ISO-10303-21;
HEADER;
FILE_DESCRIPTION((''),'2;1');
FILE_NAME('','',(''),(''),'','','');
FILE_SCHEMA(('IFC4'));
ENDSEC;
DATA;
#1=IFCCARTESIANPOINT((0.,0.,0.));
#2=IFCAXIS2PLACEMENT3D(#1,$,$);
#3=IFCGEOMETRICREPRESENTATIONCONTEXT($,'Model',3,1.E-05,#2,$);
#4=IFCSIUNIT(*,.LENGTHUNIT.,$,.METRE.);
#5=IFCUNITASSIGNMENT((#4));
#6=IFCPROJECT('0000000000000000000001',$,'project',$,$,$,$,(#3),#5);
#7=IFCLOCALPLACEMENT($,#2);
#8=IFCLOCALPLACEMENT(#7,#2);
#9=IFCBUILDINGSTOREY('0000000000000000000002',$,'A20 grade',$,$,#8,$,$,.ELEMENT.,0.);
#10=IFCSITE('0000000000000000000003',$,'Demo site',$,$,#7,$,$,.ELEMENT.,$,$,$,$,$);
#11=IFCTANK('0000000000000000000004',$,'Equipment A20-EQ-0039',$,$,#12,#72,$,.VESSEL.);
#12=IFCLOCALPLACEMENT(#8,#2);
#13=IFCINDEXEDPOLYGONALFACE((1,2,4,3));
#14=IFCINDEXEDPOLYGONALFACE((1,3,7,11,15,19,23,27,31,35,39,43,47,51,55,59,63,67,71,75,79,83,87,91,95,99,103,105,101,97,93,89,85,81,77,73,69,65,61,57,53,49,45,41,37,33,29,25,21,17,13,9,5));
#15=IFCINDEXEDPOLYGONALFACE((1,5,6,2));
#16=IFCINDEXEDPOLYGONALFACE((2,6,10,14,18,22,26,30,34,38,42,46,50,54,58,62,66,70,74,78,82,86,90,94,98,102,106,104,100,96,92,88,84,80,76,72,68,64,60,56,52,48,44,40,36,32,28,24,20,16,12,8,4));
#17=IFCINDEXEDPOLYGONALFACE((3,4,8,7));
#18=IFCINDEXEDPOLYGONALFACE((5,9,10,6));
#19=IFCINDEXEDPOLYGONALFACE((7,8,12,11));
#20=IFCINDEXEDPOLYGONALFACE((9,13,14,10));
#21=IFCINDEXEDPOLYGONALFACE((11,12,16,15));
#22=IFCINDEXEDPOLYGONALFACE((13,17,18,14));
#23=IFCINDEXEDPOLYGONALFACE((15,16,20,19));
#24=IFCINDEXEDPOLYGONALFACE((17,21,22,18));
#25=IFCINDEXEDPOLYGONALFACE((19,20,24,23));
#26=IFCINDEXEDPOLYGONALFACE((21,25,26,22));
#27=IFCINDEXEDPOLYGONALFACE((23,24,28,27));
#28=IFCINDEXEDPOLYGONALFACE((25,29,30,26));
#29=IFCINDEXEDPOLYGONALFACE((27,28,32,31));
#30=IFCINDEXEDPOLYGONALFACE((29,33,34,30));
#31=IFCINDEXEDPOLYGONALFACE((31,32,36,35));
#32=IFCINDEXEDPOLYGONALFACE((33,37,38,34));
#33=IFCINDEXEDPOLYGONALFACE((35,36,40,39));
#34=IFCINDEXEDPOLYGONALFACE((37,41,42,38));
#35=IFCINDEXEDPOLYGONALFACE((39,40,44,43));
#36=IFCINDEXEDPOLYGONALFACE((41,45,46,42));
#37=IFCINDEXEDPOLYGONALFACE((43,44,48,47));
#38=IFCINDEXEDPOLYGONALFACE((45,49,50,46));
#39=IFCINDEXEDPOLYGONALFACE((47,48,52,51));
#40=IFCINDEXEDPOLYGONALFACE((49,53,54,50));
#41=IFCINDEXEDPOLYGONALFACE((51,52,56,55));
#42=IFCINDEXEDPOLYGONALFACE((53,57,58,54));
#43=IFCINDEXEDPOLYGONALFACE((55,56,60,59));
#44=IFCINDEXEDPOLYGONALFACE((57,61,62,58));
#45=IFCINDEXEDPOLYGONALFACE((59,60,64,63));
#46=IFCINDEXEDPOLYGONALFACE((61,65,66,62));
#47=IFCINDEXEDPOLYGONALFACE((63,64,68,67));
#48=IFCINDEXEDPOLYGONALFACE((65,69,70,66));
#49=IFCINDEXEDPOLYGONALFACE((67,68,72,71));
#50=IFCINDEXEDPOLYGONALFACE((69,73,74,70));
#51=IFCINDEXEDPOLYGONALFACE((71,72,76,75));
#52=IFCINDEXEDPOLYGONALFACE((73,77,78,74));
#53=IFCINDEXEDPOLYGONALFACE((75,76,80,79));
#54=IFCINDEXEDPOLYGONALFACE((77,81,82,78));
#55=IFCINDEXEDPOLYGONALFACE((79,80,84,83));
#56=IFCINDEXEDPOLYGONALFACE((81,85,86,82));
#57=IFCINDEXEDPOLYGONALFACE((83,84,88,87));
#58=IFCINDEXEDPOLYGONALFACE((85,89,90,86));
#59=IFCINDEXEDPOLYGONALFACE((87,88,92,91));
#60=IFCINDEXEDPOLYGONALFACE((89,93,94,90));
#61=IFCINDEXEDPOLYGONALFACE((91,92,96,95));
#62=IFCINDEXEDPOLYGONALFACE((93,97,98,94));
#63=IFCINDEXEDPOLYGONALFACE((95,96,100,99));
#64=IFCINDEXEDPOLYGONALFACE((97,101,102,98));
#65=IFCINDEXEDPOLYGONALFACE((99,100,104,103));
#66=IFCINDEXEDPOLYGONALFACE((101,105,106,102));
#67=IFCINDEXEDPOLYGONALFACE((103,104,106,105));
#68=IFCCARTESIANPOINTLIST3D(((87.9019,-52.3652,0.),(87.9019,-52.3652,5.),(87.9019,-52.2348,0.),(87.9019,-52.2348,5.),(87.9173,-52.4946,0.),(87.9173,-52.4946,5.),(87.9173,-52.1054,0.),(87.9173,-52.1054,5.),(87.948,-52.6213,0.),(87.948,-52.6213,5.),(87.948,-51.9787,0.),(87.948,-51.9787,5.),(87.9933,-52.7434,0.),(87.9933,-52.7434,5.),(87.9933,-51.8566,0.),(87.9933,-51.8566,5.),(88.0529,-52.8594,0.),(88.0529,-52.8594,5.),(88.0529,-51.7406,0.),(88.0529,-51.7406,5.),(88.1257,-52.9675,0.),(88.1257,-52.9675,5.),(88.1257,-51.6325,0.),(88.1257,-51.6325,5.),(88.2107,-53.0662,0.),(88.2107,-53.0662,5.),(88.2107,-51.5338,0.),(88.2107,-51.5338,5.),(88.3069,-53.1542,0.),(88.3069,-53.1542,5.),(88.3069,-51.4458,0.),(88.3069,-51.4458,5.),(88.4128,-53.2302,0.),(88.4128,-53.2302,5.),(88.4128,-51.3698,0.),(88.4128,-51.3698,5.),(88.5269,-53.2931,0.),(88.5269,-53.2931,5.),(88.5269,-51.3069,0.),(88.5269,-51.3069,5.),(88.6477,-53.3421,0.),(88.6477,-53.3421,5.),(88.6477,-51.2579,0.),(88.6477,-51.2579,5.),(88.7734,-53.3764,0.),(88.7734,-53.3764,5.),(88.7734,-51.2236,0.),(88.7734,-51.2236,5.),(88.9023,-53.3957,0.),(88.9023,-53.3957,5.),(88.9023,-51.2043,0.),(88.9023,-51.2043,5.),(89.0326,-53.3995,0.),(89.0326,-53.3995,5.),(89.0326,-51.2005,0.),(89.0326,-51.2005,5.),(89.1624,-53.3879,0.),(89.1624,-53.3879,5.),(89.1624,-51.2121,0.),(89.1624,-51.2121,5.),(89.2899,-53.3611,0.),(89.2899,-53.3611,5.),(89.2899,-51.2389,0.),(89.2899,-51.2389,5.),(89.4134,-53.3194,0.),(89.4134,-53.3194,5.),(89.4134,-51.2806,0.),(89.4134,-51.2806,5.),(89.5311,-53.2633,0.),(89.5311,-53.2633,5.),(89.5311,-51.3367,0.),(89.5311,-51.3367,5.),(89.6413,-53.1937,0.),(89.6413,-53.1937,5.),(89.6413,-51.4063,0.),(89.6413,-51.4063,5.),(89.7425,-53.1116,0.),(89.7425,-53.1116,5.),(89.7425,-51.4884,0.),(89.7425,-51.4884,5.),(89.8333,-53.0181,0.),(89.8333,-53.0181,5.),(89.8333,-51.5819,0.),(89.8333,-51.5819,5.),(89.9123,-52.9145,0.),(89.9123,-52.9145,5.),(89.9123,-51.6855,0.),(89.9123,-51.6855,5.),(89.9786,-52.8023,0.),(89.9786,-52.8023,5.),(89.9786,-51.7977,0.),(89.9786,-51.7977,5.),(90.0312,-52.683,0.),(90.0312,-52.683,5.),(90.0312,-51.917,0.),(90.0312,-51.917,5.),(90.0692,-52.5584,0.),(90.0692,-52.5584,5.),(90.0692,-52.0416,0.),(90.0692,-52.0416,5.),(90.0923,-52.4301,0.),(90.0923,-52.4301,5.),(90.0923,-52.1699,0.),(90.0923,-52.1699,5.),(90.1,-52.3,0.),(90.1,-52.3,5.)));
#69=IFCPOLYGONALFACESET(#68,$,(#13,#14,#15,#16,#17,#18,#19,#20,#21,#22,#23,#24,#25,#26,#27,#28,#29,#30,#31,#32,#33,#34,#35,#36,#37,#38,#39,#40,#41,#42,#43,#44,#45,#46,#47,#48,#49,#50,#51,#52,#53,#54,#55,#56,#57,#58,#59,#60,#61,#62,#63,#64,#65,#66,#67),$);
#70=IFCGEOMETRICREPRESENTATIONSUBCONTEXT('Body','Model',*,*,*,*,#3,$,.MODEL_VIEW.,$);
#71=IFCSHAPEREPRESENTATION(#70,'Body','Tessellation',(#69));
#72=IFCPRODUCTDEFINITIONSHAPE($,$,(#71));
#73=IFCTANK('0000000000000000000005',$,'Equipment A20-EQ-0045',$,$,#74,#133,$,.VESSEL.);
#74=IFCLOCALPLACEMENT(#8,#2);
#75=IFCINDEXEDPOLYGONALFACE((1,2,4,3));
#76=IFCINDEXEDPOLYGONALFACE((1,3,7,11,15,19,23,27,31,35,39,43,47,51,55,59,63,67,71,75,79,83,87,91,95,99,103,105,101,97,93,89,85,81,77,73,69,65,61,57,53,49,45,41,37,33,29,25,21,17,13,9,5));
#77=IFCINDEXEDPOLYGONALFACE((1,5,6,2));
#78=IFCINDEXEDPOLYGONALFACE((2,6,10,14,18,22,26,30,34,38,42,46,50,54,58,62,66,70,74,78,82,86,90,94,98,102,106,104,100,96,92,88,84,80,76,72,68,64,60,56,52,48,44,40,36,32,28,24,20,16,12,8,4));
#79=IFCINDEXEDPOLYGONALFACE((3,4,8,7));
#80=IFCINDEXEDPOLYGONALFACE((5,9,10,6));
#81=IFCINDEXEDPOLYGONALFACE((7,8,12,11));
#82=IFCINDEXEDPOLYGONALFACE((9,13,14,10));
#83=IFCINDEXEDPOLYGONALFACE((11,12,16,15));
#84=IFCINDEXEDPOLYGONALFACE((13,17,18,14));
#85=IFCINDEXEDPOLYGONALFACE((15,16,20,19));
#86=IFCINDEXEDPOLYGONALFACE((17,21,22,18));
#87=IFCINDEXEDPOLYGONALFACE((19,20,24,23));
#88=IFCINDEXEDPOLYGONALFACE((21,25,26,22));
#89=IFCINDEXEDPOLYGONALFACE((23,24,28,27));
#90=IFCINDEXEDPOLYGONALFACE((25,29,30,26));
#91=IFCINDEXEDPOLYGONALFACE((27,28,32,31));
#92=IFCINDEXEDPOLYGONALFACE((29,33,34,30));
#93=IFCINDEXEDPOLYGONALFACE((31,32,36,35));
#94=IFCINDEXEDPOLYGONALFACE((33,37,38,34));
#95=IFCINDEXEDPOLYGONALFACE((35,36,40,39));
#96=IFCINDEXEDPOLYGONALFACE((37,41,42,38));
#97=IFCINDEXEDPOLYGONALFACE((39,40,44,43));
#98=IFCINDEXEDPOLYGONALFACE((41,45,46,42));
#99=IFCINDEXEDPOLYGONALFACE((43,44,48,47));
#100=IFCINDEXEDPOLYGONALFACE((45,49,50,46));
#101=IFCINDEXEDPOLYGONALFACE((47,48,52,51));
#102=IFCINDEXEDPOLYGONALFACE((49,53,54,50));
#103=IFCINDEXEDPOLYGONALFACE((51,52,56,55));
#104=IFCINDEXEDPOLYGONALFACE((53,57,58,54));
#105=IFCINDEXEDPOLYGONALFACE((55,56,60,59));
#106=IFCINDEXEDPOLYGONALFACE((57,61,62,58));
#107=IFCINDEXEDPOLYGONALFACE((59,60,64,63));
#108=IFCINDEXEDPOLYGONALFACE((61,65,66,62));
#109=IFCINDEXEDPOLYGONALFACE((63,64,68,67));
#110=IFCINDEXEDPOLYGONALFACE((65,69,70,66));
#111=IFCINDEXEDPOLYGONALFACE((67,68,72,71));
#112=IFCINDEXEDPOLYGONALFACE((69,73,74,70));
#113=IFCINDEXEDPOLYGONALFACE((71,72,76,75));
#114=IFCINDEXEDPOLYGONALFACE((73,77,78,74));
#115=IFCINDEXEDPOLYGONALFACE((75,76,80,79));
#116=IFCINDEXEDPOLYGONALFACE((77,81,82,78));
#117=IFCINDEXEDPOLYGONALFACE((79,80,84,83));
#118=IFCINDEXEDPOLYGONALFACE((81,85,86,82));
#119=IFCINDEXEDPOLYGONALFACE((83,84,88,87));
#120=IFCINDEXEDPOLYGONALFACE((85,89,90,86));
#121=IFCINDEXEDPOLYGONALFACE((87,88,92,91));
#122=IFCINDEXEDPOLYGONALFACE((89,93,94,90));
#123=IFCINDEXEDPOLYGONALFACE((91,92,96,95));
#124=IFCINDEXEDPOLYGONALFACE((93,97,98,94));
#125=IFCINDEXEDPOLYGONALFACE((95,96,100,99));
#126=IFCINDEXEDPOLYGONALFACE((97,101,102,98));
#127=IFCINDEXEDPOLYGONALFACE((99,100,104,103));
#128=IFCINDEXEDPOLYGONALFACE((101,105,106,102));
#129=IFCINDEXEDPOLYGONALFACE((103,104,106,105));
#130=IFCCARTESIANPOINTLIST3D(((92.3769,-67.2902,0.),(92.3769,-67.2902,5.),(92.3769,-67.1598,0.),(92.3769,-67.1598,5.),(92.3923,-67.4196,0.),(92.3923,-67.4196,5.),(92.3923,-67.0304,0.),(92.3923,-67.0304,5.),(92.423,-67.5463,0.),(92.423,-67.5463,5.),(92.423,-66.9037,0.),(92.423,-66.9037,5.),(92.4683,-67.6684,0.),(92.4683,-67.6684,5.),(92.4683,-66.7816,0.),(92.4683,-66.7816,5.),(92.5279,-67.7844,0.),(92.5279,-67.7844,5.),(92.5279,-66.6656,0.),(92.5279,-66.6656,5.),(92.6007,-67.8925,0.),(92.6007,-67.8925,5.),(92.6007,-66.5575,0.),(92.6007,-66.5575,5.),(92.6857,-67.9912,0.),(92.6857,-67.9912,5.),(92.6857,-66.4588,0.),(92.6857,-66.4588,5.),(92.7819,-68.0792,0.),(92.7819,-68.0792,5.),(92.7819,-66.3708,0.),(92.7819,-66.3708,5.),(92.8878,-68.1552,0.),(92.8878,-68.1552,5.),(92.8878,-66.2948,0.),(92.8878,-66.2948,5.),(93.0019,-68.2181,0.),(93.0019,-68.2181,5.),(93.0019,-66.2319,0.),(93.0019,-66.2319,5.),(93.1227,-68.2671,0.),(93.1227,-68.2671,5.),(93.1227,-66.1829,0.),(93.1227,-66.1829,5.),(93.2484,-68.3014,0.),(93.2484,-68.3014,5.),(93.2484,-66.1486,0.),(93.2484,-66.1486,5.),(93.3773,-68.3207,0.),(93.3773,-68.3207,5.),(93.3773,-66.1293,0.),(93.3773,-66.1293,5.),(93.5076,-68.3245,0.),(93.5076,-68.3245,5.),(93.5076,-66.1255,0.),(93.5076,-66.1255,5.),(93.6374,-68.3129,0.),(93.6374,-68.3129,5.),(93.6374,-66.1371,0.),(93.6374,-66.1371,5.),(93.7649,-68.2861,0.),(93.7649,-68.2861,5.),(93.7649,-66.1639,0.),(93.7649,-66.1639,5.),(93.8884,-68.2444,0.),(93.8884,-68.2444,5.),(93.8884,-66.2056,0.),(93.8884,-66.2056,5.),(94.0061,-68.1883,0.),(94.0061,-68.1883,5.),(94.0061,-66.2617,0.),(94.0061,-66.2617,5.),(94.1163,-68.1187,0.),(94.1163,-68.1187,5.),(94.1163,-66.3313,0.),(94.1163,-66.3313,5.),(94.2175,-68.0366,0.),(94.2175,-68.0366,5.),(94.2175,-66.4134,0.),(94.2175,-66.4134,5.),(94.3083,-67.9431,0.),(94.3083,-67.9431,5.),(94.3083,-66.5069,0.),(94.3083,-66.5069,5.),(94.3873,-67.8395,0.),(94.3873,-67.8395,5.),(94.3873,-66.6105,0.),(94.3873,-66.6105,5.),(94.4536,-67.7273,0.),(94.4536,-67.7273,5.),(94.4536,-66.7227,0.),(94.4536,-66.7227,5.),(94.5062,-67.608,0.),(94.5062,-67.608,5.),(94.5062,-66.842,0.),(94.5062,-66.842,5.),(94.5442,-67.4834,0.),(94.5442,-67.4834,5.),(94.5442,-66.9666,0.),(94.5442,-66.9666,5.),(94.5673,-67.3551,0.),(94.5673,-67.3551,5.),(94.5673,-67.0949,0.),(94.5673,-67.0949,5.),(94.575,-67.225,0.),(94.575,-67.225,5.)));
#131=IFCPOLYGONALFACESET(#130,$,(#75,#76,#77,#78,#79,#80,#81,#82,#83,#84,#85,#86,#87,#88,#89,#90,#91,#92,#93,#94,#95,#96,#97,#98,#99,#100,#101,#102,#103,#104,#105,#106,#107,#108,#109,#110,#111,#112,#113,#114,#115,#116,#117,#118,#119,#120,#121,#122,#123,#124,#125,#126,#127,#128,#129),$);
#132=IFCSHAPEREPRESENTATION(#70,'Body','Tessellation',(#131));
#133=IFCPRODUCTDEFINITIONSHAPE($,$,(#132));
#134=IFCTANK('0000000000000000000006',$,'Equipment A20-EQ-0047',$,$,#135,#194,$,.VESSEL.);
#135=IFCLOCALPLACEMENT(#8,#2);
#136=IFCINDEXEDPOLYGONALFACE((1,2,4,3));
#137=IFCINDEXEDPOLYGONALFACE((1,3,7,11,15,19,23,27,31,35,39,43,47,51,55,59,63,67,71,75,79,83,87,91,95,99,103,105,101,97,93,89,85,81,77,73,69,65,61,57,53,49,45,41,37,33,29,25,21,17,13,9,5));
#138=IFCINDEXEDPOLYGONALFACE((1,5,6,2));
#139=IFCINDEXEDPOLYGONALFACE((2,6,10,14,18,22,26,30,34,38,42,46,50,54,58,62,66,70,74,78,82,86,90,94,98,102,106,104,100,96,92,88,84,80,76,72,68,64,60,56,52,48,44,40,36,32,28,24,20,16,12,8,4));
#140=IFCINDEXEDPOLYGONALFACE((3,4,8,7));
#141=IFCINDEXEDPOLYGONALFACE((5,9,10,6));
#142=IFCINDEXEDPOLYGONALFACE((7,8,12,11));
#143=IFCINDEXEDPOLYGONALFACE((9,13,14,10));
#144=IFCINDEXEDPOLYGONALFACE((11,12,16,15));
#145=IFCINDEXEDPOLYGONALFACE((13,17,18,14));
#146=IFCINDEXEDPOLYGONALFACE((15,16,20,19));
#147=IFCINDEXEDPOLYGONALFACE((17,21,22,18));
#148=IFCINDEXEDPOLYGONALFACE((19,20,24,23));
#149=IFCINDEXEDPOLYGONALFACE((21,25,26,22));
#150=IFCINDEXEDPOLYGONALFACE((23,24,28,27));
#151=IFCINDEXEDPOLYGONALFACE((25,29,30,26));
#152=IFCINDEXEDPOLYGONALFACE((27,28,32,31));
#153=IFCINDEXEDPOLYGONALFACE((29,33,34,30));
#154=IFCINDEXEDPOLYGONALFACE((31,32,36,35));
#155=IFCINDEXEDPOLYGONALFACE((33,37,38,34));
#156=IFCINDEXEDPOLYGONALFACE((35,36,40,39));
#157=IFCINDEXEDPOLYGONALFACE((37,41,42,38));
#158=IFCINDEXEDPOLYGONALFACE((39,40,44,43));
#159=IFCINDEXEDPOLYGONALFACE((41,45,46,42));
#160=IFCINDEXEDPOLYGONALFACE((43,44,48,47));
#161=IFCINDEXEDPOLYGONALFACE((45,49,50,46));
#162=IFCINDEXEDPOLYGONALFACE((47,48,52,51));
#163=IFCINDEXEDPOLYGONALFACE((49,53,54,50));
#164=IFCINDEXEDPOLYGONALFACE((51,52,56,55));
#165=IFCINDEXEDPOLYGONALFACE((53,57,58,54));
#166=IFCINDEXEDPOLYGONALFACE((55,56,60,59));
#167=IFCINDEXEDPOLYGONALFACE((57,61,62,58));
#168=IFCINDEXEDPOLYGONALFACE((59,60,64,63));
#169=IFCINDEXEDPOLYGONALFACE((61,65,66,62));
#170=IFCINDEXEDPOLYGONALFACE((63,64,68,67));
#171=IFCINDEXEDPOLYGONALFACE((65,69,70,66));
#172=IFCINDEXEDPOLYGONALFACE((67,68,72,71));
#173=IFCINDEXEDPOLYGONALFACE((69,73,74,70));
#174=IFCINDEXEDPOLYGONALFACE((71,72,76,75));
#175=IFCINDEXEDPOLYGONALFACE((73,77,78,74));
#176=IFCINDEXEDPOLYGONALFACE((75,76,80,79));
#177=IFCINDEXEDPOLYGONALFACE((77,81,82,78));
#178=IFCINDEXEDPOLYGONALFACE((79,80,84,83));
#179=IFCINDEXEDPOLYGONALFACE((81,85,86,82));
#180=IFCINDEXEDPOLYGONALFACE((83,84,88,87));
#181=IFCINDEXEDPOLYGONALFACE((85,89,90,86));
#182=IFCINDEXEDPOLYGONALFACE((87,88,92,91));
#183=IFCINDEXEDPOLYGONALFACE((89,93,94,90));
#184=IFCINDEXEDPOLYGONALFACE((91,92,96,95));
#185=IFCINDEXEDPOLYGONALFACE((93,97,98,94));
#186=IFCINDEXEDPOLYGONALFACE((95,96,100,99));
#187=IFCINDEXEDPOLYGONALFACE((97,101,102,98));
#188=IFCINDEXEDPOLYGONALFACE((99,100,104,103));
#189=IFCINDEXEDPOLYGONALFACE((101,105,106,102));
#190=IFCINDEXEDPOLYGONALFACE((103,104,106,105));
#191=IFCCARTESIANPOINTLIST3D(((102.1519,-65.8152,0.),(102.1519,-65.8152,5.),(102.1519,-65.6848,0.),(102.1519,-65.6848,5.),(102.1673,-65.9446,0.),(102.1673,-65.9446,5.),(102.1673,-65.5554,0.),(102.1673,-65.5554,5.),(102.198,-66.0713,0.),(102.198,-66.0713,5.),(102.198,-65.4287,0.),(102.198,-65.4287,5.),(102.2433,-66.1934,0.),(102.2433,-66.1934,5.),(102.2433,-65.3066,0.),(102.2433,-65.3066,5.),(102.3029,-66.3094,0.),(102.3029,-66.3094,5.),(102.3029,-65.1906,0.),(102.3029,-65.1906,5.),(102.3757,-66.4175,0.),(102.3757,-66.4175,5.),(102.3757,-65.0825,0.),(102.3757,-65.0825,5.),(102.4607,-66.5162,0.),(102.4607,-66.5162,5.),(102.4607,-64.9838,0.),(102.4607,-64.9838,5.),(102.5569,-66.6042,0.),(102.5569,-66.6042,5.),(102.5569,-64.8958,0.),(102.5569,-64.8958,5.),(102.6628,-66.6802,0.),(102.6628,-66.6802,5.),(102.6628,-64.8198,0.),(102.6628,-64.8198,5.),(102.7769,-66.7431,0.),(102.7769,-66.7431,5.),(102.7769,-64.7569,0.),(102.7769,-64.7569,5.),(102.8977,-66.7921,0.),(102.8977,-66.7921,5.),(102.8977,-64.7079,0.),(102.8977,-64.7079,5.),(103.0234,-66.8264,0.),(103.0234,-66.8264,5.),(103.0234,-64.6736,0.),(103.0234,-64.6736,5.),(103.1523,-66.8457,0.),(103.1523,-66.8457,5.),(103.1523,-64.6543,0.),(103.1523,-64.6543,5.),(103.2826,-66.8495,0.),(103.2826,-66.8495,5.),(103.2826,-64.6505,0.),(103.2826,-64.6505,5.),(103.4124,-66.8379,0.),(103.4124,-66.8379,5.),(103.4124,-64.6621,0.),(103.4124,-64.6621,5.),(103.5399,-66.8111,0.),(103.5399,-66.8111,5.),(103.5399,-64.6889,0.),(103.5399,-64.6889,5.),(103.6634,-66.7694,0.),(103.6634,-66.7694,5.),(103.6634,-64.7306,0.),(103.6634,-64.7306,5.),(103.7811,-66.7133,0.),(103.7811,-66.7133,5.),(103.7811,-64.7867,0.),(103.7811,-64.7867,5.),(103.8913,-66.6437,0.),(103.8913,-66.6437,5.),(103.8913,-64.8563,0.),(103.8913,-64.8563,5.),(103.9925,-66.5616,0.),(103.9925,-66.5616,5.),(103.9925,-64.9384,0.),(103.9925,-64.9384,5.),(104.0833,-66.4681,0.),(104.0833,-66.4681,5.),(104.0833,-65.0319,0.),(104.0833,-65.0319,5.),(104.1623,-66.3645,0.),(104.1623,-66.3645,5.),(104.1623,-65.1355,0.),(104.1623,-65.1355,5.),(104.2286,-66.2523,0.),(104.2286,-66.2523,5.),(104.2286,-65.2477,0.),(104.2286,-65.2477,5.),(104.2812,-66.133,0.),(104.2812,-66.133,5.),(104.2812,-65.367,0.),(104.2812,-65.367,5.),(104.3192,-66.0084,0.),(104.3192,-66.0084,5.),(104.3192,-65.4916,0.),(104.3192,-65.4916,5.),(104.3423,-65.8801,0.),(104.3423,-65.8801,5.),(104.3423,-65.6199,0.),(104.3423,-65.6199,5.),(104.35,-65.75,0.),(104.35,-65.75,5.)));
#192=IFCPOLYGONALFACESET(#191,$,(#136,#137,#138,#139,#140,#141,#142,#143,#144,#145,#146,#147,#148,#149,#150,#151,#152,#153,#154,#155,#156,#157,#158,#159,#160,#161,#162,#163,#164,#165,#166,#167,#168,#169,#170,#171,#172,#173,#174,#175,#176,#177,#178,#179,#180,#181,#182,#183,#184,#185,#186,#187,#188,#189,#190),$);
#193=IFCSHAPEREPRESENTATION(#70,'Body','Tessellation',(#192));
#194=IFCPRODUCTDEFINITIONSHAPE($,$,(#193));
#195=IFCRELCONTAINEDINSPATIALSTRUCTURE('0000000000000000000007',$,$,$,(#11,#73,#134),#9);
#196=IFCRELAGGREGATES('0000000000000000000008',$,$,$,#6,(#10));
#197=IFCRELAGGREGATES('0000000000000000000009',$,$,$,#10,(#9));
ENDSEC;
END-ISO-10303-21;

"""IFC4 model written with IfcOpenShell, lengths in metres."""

from ifc_helpers import new_model, si_unit, frame, origin, place, context, subcontext, project, spatial, circle, extrude, element, save


model = new_model("IFC4")

# Units and contexts
model_context = context("Model", 3, precision=1e-05, world=origin())
body_context = subcontext(model_context, "Body", "Model", "MODEL_VIEW")
ifc_project = project(units=[si_unit("LENGTHUNIT", "METRE")], contexts=[model_context])

# Site, storey
site_placement = place(None, origin())
site = spatial("IfcSite", under=ifc_project, at=site_placement, Name="Demo site", CompositionType="ELEMENT")
storey_placement = place(site_placement, origin())
storey = spatial("IfcBuildingStorey", under=site, at=storey_placement, Name="A20 grade", CompositionType="ELEMENT", Elevation=0.0)

# Tanks
for number, where, name in (
    (1, (89.0, -52.3, 0.0), "Equipment A20-EQ-0039"),
    (2, (93.475, -67.225, 0.0), "Equipment A20-EQ-0045"),
    (3, (103.25, -65.75, 0.0), "Equipment A20-EQ-0047"),
):
    element("IfcTank", number, at=place(storey_placement, frame(where)), inside=storey, Name=name, PredefinedType="VESSEL", context=body_context, shape_type="SweptSolid", body=[
        extrude(circle(Radius=1.1), origin(), (0.0, 0.0, 1.0), 5.0),
    ])

save(model, "model.ifc")
